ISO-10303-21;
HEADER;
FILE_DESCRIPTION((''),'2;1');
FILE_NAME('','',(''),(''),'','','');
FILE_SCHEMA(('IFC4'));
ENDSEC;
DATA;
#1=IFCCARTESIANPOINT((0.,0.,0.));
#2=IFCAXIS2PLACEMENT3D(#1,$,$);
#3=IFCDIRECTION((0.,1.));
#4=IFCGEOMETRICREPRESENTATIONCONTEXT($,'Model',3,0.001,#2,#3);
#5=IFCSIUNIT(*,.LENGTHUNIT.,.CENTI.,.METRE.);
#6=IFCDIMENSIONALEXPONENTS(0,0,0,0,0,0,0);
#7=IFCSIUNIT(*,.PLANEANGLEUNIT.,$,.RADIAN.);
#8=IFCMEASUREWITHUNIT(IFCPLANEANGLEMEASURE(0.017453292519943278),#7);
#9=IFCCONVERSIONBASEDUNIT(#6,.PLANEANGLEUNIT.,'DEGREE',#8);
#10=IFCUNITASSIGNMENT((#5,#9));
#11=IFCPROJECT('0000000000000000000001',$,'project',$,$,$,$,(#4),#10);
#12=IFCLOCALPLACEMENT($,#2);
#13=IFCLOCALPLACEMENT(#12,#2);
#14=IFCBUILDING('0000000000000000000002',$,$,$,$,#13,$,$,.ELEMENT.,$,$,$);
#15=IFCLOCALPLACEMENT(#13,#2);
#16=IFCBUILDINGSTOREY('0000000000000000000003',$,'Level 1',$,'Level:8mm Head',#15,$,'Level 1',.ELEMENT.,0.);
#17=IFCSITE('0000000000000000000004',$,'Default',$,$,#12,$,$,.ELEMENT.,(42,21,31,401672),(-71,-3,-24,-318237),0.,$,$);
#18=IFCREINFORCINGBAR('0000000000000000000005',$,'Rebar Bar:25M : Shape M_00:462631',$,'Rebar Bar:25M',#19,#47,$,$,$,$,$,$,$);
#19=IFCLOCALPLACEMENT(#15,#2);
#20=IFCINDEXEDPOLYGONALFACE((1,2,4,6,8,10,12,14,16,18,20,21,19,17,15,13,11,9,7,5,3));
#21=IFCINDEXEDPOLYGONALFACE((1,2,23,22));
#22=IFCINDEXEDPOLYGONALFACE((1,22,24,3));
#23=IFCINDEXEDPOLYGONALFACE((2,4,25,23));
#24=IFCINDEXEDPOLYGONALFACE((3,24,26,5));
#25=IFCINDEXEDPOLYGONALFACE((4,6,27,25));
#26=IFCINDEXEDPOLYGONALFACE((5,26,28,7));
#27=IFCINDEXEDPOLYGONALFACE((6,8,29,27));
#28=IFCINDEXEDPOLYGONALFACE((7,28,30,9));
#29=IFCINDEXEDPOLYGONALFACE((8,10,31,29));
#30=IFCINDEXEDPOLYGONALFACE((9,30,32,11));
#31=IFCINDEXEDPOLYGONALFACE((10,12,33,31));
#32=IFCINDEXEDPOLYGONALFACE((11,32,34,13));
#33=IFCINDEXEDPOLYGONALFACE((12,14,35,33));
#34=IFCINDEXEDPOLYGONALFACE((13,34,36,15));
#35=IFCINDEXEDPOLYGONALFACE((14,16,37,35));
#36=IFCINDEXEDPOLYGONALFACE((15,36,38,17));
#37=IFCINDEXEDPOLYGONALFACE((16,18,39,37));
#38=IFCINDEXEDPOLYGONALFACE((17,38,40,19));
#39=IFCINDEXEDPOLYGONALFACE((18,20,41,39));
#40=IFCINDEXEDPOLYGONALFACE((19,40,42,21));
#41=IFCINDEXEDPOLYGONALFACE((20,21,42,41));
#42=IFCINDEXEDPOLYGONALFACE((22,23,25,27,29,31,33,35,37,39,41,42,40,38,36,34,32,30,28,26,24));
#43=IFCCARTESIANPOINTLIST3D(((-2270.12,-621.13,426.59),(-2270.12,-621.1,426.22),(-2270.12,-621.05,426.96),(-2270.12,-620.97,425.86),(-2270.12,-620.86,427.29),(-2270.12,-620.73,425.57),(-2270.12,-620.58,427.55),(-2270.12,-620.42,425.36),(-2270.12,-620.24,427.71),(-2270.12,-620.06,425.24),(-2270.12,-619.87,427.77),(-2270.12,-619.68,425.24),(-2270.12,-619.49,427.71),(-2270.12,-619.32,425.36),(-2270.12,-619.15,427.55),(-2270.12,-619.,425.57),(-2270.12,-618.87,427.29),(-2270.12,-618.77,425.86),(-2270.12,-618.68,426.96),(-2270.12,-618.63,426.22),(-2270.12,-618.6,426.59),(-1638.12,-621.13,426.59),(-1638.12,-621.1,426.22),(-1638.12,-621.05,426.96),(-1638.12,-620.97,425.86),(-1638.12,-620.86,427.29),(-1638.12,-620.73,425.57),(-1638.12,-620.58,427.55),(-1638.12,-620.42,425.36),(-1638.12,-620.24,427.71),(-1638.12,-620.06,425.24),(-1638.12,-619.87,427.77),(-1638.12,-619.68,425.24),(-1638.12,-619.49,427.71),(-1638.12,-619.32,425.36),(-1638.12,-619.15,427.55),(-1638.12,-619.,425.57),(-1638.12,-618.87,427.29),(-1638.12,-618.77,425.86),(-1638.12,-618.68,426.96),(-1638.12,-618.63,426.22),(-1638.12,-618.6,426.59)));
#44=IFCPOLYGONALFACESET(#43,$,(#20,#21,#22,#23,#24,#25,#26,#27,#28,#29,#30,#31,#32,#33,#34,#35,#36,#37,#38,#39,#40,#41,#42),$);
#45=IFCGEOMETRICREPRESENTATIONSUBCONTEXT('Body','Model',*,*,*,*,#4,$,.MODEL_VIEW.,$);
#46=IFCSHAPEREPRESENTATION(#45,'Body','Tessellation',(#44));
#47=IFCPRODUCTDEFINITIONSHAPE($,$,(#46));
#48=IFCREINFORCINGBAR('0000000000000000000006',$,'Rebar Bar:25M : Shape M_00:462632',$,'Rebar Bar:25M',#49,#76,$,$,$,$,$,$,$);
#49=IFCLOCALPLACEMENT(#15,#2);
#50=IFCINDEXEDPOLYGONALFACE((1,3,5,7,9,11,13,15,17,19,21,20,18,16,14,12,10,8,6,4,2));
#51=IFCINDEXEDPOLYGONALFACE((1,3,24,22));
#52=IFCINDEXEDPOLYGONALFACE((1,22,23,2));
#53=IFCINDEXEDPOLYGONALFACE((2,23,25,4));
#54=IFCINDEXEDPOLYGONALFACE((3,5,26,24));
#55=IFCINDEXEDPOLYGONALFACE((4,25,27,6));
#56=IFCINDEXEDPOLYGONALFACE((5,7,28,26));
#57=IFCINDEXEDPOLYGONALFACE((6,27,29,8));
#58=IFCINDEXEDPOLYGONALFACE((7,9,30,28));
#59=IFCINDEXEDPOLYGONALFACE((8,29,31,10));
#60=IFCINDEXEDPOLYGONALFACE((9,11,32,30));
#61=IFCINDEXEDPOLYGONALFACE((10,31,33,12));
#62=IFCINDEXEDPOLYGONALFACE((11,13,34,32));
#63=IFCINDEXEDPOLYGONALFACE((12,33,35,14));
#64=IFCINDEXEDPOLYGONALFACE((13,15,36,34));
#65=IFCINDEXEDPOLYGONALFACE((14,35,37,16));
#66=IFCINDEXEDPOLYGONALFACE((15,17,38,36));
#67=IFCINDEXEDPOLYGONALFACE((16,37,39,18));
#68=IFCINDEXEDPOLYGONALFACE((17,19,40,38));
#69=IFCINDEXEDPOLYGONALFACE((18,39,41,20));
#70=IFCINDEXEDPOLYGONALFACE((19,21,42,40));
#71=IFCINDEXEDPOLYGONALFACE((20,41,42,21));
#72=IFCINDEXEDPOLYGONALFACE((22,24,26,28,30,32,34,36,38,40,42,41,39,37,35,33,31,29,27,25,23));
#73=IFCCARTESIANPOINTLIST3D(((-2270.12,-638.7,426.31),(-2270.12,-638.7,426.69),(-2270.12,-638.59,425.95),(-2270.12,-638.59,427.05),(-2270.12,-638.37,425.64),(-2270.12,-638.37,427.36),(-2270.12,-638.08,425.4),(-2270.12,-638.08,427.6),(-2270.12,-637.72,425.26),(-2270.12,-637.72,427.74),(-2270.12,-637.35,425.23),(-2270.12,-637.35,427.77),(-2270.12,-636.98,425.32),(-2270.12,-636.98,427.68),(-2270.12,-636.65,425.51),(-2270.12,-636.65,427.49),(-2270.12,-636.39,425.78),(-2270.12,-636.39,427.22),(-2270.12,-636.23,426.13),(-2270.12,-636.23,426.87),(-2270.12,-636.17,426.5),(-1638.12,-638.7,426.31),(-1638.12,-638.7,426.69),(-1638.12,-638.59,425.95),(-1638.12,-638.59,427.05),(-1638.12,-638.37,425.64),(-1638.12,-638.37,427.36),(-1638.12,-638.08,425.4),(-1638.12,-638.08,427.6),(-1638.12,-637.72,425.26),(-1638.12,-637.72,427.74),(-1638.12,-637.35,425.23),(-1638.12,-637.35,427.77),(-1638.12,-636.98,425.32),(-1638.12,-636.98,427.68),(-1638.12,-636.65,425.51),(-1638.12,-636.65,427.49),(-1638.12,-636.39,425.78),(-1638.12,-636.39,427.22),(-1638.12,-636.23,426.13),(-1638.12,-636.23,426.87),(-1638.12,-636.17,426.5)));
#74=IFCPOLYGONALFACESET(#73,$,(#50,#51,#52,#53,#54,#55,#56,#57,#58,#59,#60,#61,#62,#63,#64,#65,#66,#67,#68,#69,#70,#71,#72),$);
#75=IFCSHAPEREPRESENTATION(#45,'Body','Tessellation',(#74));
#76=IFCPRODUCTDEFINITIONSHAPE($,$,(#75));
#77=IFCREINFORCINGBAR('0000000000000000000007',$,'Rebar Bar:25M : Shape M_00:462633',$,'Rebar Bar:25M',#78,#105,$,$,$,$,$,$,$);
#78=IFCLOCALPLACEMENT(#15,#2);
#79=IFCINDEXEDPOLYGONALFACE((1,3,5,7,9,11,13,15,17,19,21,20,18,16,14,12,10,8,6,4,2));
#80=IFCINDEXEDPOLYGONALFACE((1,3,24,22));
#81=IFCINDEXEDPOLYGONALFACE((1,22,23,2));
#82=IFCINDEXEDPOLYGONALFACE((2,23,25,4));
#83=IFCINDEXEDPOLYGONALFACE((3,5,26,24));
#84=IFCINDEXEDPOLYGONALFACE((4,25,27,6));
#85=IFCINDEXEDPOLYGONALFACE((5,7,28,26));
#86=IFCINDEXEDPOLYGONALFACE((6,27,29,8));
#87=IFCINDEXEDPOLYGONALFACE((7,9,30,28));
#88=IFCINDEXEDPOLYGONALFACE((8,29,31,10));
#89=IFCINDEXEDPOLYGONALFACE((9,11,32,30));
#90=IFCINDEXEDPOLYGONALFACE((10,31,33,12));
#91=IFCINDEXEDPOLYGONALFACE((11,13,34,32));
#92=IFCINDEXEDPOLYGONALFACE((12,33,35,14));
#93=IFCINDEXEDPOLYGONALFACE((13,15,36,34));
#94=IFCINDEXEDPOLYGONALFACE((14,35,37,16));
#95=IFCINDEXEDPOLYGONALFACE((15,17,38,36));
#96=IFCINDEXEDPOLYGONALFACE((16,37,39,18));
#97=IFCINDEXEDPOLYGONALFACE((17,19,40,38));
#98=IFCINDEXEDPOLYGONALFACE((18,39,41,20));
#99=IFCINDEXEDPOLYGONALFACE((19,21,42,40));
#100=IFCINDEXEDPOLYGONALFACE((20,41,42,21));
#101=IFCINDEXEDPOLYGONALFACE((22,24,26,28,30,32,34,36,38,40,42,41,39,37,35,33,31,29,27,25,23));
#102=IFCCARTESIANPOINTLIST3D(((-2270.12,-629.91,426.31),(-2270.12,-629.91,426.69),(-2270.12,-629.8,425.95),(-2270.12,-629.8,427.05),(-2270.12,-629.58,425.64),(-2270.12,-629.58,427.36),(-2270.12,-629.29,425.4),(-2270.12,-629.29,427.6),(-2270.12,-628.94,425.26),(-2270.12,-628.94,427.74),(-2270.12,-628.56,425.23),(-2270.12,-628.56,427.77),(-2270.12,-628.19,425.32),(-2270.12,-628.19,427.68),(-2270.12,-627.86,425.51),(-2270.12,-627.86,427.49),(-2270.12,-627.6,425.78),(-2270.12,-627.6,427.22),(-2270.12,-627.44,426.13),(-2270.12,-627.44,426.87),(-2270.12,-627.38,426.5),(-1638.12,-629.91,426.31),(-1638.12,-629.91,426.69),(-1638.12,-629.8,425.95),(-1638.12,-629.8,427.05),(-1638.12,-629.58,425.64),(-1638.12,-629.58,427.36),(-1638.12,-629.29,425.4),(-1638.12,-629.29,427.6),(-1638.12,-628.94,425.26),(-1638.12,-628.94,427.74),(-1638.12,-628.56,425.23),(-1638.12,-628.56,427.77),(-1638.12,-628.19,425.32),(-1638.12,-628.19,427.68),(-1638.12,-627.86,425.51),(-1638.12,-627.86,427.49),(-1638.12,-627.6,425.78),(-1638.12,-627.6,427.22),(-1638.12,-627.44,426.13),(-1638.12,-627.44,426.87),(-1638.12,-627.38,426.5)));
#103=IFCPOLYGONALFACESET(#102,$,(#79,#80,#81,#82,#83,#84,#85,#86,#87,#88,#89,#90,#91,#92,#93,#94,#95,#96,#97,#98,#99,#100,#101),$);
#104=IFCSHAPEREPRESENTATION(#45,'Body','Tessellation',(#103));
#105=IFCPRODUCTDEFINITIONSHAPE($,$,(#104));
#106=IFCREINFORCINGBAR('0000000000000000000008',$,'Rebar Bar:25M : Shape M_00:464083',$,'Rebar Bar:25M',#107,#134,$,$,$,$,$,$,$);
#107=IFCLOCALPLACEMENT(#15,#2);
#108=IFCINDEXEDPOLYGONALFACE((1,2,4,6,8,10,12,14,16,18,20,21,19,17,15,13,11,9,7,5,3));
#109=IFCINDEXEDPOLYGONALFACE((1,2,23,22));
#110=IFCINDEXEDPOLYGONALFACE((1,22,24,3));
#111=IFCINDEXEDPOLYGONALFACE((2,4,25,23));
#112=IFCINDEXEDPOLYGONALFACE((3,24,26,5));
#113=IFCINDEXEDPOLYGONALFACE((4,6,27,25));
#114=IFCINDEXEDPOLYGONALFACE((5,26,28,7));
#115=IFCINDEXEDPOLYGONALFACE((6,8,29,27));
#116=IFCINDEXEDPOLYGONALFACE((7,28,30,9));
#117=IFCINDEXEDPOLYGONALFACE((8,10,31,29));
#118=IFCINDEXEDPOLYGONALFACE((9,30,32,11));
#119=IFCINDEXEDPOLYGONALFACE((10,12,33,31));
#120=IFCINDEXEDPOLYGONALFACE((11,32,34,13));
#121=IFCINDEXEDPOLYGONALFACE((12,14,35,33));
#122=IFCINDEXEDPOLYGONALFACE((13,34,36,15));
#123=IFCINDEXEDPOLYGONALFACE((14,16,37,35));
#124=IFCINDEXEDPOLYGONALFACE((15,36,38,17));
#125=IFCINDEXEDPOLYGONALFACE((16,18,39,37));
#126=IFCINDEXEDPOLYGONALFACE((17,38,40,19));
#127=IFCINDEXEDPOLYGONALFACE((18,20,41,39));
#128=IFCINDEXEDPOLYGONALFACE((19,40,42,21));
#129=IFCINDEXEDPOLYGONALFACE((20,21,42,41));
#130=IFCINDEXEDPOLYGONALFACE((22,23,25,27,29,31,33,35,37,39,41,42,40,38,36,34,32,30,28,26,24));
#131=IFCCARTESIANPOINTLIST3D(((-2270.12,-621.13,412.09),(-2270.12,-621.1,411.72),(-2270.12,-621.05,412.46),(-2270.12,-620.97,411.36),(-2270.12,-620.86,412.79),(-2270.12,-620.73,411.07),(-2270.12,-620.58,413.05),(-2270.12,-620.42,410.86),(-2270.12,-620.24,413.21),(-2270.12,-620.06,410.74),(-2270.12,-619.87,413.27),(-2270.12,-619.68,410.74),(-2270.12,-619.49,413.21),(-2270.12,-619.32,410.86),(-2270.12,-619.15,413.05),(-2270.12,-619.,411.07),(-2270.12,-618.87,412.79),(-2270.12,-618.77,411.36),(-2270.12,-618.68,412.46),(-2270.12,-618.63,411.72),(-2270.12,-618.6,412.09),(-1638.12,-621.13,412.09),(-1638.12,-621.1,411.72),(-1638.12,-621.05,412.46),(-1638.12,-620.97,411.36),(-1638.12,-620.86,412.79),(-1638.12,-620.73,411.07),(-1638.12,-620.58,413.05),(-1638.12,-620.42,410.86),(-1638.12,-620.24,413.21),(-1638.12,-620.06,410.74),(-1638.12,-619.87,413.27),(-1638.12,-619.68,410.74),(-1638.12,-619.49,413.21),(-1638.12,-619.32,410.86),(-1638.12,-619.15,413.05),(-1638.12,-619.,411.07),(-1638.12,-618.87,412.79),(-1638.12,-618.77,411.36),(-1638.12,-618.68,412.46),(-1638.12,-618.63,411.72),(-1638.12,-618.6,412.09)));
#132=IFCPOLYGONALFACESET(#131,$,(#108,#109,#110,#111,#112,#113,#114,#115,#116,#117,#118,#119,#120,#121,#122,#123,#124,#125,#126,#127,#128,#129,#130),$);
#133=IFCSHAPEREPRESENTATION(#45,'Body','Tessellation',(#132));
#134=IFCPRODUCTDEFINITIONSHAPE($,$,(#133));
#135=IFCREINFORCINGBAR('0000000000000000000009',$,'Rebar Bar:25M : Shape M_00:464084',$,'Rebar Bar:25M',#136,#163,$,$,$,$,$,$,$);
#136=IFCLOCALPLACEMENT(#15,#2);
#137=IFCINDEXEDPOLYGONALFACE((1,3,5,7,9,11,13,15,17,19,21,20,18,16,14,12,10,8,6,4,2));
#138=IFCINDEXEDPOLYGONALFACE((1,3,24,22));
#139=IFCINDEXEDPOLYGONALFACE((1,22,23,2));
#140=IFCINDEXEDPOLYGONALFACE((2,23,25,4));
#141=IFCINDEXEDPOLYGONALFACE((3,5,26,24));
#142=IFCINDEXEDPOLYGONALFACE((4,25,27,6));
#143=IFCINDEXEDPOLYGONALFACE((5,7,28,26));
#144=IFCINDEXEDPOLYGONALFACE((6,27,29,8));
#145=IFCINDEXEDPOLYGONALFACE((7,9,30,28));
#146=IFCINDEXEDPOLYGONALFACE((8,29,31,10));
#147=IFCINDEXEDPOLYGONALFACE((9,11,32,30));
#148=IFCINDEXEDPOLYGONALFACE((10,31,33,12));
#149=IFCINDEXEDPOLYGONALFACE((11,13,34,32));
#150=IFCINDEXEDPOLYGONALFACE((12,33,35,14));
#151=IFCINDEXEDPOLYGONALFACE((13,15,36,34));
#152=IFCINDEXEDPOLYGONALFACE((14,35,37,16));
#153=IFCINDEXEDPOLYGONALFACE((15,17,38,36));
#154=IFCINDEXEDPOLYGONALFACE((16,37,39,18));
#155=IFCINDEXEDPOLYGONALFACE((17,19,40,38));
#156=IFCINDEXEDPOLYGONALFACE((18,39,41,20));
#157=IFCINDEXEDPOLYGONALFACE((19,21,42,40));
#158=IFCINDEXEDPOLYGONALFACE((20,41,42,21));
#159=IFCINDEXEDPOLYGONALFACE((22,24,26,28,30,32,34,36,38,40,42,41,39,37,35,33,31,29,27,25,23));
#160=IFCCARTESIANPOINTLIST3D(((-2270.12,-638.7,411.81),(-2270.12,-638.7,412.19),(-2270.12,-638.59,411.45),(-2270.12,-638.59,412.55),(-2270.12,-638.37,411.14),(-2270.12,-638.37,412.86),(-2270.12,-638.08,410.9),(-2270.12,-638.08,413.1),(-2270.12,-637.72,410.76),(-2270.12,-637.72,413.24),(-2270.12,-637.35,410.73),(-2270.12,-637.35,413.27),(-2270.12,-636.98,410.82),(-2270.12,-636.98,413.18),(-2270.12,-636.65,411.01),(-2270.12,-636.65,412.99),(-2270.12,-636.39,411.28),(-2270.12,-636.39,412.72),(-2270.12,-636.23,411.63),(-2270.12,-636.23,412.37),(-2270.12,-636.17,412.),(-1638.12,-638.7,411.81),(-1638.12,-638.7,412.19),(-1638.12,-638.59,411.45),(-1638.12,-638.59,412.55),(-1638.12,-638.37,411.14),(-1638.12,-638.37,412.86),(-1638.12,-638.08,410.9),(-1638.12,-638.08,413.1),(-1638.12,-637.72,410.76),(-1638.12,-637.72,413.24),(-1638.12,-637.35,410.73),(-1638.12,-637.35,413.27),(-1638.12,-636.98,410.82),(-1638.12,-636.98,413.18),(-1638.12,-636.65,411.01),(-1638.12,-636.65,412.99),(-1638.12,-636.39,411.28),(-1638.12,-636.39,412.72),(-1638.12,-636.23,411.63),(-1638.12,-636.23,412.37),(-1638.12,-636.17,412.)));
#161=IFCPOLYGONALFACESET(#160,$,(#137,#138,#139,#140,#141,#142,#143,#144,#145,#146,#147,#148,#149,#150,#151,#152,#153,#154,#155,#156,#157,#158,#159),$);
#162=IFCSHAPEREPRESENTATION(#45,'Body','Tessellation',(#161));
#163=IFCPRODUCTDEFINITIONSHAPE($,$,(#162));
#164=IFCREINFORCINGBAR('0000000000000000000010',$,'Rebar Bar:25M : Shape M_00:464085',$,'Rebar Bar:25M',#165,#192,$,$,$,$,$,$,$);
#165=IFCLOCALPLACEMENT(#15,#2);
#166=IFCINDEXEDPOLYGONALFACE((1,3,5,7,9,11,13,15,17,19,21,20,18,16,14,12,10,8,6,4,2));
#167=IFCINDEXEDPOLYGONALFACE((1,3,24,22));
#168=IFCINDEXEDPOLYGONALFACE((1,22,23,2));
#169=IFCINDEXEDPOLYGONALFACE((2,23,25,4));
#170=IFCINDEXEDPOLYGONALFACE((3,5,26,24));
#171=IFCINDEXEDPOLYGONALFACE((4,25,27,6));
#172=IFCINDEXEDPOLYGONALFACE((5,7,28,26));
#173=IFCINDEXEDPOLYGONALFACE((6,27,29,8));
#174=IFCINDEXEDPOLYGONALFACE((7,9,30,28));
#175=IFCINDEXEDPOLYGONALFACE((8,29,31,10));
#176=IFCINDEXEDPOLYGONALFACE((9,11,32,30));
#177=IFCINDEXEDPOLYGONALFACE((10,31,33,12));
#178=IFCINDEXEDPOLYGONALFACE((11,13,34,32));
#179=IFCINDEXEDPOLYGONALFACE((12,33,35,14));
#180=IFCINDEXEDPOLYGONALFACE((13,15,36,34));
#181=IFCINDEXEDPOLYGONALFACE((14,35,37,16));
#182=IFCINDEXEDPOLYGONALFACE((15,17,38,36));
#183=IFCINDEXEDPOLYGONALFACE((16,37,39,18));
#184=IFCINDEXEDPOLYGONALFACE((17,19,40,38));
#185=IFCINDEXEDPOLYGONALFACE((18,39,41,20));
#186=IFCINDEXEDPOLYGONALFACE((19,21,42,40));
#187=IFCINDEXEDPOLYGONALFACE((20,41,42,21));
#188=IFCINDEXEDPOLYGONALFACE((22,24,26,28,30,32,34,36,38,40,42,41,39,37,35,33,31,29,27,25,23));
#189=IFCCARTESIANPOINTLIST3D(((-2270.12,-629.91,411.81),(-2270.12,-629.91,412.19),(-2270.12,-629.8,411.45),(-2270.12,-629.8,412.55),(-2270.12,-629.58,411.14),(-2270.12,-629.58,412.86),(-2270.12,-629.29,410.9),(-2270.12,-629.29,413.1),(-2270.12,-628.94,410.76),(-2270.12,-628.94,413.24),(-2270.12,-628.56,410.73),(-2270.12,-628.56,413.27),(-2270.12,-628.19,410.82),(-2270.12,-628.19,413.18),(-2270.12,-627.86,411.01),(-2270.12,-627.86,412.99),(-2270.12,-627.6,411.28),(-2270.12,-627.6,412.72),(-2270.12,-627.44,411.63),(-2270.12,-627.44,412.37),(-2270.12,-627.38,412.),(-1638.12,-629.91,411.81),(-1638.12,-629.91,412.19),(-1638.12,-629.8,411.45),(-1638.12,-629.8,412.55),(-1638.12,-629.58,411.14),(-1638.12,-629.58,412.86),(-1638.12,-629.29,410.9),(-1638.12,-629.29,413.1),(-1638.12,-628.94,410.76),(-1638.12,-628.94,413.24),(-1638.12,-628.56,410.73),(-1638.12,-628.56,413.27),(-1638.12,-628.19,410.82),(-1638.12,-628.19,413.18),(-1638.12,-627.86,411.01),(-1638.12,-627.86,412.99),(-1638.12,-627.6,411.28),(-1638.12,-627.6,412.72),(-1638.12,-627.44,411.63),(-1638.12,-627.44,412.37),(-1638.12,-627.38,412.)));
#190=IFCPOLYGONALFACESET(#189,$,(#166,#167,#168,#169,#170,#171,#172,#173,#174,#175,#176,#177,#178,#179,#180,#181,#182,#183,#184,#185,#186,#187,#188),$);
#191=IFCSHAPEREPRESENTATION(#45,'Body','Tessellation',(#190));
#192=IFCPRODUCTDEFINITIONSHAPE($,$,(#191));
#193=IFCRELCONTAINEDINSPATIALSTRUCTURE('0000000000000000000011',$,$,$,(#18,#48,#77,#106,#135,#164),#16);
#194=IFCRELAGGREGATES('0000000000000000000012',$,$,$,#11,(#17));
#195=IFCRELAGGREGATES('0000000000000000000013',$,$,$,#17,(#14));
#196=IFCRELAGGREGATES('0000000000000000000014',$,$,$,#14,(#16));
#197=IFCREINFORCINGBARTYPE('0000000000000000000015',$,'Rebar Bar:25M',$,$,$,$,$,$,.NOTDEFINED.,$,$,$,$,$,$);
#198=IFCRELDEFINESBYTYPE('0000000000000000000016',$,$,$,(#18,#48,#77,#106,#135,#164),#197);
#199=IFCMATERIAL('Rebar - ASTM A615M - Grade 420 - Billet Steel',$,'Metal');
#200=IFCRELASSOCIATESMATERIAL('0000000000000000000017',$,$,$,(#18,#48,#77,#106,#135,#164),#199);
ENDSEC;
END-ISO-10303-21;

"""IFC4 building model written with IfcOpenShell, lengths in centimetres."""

from ifc_helpers import new_model, entity, si_unit, converted_unit, direction, origin, place, context, subcontext, project, spatial, material, type_object, element, save


model = new_model("IFC4")

# Units and contexts
model_context = context("Model", 3, precision=0.001, world=origin(), true_north=direction((0.0, 1.0)))
body_context = subcontext(model_context, "Body", "Model", "MODEL_VIEW")
ifc_project = project(units=[si_unit("LENGTHUNIT", "METRE", prefix="CENTI"), converted_unit("PLANEANGLEUNIT", "DEGREE", entity("IfcPlaneAngleMeasure", 0.017453292519943278), si_unit("PLANEANGLEUNIT", "RADIAN"), dimensions=[0, 0, 0, 0, 0, 0, 0])], contexts=[model_context])

# Site, building, storey
site_placement = place(None, origin())
site = spatial("IfcSite", under=ifc_project, at=site_placement, Name="Default", CompositionType="ELEMENT", RefLatitude=(42, 21, 31, 401672), RefLongitude=(-71, -3, -24, -318237), RefElevation=0.0)
building_placement = place(site_placement, origin())
building = spatial("IfcBuilding", under=site, at=building_placement, CompositionType="ELEMENT")
storey_placement = place(building_placement, origin())
storey = spatial("IfcBuildingStorey", under=building, at=storey_placement, Name="Level 1", ObjectType="Level:8mm Head", LongName="Level 1", CompositionType="ELEMENT", Elevation=0.0)

# Reinforcing bars
ifc_material = material(Name="Rebar - ASTM A615M - Grade 420 - Billet Steel", Category="Metal")
reinforcing_bar_type_1 = type_object("IfcReinforcingBarType", Name="Rebar Bar:25M", PredefinedType="NOTDEFINED")
reinforcing_bar_1_placement = place(storey_placement, origin())
element("IfcReinforcingBar", 1, at=reinforcing_bar_1_placement, inside=storey, type_object=reinforcing_bar_type_1, material=ifc_material, Name="Rebar Bar:25M : Shape M_00:462631", ObjectType="Rebar Bar:25M", context=body_context, shape_type="AdvancedSweptSolid", body=[
    entity("IfcSweptDiskSolid", entity("IfcIndexedPolyCurve", entity("IfcCartesianPointList3D", [[-2270.12, -619.87, 426.5], [-1638.12, -619.87, 426.5]]), None, False), 1.27, None, 0.0, 1.0),
])
reinforcing_bar_2_placement = place(storey_placement, origin())
element("IfcReinforcingBar", 2, at=reinforcing_bar_2_placement, inside=storey, type_object=reinforcing_bar_type_1, material=ifc_material, Name="Rebar Bar:25M : Shape M_00:462632", ObjectType="Rebar Bar:25M", context=body_context, shape_type="AdvancedSweptSolid", body=[
    entity("IfcSweptDiskSolid", entity("IfcIndexedPolyCurve", entity("IfcCartesianPointList3D", [[-2270.12, -637.44, 426.5], [-1638.12, -637.44, 426.5]]), None, False), 1.27, None, 0.0, 1.0),
])
reinforcing_bar_3_placement = place(storey_placement, origin())
element("IfcReinforcingBar", 3, at=reinforcing_bar_3_placement, inside=storey, type_object=reinforcing_bar_type_1, material=ifc_material, Name="Rebar Bar:25M : Shape M_00:462633", ObjectType="Rebar Bar:25M", context=body_context, shape_type="AdvancedSweptSolid", body=[
    entity("IfcSweptDiskSolid", entity("IfcIndexedPolyCurve", entity("IfcCartesianPointList3D", [[-2270.12, -628.65, 426.5], [-1638.12, -628.65, 426.5]]), None, False), 1.27, None, 0.0, 1.0),
])
reinforcing_bar_4_placement = place(storey_placement, origin())
element("IfcReinforcingBar", 4, at=reinforcing_bar_4_placement, inside=storey, type_object=reinforcing_bar_type_1, material=ifc_material, Name="Rebar Bar:25M : Shape M_00:464083", ObjectType="Rebar Bar:25M", context=body_context, shape_type="AdvancedSweptSolid", body=[
    entity("IfcSweptDiskSolid", entity("IfcIndexedPolyCurve", entity("IfcCartesianPointList3D", [[-2270.12, -619.87, 412.0], [-1638.12, -619.87, 412.0]]), None, False), 1.27, None, 0.0, 1.0),
])
reinforcing_bar_5_placement = place(storey_placement, origin())
element("IfcReinforcingBar", 5, at=reinforcing_bar_5_placement, inside=storey, type_object=reinforcing_bar_type_1, material=ifc_material, Name="Rebar Bar:25M : Shape M_00:464084", ObjectType="Rebar Bar:25M", context=body_context, shape_type="AdvancedSweptSolid", body=[
    entity("IfcSweptDiskSolid", entity("IfcIndexedPolyCurve", entity("IfcCartesianPointList3D", [[-2270.12, -637.44, 412.0], [-1638.12, -637.44, 412.0]]), None, False), 1.27, None, 0.0, 1.0),
])
reinforcing_bar_6_placement = place(storey_placement, origin())
element("IfcReinforcingBar", 6, at=reinforcing_bar_6_placement, inside=storey, type_object=reinforcing_bar_type_1, material=ifc_material, Name="Rebar Bar:25M : Shape M_00:464085", ObjectType="Rebar Bar:25M", context=body_context, shape_type="AdvancedSweptSolid", body=[
    entity("IfcSweptDiskSolid", entity("IfcIndexedPolyCurve", entity("IfcCartesianPointList3D", [[-2270.12, -628.65, 412.0], [-1638.12, -628.65, 412.0]]), None, False), 1.27, None, 0.0, 1.0),
])

save(model, "model.ifc")
